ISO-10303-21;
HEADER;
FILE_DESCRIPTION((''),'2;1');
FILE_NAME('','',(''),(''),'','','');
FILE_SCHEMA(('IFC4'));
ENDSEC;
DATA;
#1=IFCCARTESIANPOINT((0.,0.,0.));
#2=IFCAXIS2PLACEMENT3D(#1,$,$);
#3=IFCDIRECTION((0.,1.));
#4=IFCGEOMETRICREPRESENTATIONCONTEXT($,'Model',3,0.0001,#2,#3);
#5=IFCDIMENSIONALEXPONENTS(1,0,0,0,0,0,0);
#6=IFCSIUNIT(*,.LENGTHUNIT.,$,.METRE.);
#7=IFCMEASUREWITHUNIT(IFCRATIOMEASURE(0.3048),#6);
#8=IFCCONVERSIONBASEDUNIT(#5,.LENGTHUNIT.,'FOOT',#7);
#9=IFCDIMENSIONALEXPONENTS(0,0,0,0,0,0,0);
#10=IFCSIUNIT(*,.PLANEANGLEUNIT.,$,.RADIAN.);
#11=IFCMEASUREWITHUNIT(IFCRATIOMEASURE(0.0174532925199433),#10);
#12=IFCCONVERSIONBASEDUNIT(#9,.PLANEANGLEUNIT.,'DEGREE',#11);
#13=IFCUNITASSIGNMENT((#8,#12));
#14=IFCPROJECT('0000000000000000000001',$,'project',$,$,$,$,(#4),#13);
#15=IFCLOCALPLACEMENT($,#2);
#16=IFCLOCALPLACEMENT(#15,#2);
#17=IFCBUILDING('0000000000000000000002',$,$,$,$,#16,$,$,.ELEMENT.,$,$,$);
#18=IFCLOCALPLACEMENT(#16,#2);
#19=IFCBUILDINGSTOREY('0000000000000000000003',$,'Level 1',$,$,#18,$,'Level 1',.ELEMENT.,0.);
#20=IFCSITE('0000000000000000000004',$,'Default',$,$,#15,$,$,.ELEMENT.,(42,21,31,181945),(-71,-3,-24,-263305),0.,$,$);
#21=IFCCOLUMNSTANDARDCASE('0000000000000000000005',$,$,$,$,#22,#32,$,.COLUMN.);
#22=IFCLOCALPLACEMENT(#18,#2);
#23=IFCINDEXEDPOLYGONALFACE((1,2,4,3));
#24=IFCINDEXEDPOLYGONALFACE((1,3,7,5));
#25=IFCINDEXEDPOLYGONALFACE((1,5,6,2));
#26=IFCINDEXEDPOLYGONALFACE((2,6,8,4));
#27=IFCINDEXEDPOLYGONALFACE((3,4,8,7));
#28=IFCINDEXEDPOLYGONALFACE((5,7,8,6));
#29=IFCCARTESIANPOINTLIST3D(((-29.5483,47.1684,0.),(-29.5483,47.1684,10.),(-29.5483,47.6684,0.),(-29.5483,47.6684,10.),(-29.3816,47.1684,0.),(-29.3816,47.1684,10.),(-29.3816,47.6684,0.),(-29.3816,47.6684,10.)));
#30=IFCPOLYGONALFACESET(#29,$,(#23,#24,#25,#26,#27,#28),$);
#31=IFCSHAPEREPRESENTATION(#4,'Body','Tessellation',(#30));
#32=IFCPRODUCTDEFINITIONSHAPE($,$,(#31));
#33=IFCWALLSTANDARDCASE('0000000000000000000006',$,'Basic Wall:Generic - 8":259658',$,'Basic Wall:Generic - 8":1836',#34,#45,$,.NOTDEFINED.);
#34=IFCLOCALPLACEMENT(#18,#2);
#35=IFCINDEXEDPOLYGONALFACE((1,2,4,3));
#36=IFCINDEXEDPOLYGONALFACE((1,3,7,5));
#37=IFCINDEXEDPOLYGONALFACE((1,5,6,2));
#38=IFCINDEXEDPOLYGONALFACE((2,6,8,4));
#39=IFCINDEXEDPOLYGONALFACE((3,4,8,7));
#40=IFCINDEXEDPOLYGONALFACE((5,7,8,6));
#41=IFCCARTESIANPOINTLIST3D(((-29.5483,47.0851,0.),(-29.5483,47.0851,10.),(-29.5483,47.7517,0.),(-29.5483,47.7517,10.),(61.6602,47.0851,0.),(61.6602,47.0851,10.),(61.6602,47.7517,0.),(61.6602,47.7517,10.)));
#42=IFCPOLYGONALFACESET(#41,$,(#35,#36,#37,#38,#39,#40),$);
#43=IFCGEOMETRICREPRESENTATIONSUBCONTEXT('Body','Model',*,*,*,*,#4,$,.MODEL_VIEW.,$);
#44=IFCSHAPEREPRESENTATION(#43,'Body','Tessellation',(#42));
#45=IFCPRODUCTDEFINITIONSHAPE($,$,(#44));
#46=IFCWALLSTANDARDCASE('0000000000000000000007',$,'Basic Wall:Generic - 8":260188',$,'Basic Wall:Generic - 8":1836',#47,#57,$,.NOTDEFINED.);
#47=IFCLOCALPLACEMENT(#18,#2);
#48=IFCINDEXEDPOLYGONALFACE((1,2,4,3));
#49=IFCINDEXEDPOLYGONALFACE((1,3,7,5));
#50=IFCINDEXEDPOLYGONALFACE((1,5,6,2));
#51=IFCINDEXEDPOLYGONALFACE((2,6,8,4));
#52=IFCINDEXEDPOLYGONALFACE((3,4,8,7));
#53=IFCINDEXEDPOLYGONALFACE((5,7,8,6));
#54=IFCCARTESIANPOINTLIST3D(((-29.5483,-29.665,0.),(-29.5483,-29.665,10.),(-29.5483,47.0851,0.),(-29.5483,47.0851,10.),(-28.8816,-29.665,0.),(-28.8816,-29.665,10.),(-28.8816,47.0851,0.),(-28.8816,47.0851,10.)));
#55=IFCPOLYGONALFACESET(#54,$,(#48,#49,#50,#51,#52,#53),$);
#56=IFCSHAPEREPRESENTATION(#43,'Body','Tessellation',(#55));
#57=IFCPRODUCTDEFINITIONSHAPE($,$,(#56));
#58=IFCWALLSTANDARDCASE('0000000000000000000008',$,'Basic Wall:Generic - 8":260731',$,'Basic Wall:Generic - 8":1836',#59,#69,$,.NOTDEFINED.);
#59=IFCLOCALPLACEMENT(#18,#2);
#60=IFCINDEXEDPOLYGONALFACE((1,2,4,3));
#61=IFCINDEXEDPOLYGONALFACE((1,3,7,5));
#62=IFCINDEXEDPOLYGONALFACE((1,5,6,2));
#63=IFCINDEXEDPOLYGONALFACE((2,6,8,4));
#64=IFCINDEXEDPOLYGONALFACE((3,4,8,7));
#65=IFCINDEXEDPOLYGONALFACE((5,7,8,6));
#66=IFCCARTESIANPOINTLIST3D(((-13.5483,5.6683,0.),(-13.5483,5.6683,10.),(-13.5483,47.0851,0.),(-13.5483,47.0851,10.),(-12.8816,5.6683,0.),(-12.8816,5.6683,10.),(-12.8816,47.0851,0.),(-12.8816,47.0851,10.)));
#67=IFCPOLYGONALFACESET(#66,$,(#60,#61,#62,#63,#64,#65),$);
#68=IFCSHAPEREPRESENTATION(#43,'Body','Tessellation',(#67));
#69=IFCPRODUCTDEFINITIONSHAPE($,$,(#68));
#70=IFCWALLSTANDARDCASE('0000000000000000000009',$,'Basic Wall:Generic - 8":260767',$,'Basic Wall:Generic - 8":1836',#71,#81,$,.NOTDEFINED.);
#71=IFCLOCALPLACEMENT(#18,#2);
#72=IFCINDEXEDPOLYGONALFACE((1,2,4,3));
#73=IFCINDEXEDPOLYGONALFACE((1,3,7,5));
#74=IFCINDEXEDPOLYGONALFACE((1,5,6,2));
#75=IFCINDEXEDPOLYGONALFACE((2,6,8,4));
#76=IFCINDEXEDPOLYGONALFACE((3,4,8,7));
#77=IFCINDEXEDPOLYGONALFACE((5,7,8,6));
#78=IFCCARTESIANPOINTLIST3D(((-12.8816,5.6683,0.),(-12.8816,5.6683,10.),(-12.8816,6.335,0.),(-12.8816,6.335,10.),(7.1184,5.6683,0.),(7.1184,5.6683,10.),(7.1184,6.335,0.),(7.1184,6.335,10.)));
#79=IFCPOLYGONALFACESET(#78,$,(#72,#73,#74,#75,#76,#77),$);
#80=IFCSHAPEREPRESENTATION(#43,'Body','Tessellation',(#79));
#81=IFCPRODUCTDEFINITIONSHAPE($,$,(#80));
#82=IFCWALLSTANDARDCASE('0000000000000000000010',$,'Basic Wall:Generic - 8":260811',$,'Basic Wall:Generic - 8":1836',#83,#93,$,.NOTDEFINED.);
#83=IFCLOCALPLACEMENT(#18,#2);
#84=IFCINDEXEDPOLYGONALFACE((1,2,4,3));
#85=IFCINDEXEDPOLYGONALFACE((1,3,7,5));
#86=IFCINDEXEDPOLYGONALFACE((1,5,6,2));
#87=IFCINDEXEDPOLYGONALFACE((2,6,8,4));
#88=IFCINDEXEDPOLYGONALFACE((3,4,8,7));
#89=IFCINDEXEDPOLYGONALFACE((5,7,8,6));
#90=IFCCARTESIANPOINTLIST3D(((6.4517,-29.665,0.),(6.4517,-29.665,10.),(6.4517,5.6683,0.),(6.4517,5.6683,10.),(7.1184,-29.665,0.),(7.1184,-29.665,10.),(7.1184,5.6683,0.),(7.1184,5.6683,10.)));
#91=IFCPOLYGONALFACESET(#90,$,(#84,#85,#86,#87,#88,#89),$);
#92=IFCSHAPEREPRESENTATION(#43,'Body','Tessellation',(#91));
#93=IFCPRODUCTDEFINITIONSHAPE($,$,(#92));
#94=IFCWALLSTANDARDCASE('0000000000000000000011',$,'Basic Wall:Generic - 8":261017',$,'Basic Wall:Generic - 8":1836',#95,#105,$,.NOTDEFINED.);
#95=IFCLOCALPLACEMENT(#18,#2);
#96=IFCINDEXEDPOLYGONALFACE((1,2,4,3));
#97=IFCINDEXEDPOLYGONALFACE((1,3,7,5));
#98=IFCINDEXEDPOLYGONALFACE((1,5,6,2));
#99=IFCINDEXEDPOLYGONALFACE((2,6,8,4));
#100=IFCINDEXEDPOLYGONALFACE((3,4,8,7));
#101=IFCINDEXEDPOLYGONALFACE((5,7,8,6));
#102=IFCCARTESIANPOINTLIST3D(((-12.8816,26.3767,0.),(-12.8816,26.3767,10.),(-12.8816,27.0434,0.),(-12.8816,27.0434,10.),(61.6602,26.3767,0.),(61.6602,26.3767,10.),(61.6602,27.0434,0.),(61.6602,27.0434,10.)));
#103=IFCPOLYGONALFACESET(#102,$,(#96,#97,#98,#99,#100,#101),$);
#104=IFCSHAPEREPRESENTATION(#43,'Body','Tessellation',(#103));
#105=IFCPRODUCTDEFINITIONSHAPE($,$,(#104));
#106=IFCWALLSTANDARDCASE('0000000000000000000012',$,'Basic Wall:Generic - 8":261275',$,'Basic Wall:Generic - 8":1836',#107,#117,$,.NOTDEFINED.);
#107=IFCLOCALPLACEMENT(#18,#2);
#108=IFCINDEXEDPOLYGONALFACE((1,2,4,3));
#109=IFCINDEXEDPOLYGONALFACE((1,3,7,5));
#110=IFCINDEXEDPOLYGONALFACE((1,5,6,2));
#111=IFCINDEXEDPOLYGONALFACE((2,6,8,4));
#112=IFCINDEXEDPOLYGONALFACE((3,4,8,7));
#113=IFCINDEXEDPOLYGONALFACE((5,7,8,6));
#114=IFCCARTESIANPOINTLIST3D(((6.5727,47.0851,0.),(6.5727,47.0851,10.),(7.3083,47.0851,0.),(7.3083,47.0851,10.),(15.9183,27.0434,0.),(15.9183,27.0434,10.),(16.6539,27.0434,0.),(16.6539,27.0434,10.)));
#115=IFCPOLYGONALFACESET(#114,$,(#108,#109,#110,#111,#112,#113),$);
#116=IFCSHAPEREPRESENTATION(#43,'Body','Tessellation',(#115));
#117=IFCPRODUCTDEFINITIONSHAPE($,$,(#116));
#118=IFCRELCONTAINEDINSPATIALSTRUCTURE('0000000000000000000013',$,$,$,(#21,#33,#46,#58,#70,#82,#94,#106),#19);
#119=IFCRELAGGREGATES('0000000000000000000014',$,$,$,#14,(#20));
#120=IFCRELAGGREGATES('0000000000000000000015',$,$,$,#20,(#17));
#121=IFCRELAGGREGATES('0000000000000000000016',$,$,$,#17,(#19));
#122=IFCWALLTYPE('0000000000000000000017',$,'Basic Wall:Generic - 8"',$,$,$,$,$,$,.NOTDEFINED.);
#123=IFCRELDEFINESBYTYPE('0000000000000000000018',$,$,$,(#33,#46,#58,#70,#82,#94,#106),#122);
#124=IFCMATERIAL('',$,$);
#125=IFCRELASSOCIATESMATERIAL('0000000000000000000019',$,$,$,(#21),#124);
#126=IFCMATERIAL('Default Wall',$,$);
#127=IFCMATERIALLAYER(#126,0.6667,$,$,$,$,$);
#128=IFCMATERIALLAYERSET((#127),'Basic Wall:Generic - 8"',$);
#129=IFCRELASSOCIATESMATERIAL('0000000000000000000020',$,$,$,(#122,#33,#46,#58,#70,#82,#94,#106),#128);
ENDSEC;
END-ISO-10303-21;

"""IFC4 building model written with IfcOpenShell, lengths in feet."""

from ifc_helpers import new_model, entity, si_unit, converted_unit, direction, frame, frame_2d, origin, place, context, subcontext, project, spatial, polyline, rectangle, outline, extrude, material, layer, layer_set, layer_usage, type_object, element, save


model = new_model("IFC4")

# Units and contexts
model_context = context("Model", 3, precision=0.0001, world=origin(), true_north=direction((0.0, 1.0)))
body_context = subcontext(model_context, "Body", "Model", "MODEL_VIEW")
ifc_project = project(units=[converted_unit("LENGTHUNIT", "FOOT", entity("IfcRatioMeasure", 0.3048), si_unit("LENGTHUNIT", "METRE"), dimensions=[1, 0, 0, 0, 0, 0, 0]), converted_unit("PLANEANGLEUNIT", "DEGREE", entity("IfcRatioMeasure", 0.0174532925199433), si_unit("PLANEANGLEUNIT", "RADIAN"), dimensions=[0, 0, 0, 0, 0, 0, 0])], contexts=[model_context])

# Site, building, storey
site_placement = place(None, origin())
site = spatial("IfcSite", under=ifc_project, at=site_placement, Name="Default", CompositionType="ELEMENT", RefLatitude=(42, 21, 31, 181945), RefLongitude=(-71, -3, -24, -263305), RefElevation=0.0)
building_placement = place(site_placement, origin())
building = spatial("IfcBuilding", under=site, at=building_placement, CompositionType="ELEMENT")
storey_placement = place(building_placement, origin())
storey = spatial("IfcBuildingStorey", under=building, at=storey_placement, Name="Level 1", LongName="Level 1", CompositionType="ELEMENT", Elevation=0.0)

# Column
ifc_material_1 = material(Name="")
wall_1_placement = place(storey_placement, frame((-29.5483, 47.4184, 0.0)))
for number, where, z_axis, x_axis in (
    (1, (0.0833, 0.0, 0.0), (0.0, 0.0, 1.0), (1.0, 0.0, 0.0)),
):
    element("IfcColumnStandardCase", number, at=place(wall_1_placement, frame(where, z_axis=z_axis, x_axis=x_axis)), inside=storey, material=ifc_material_1, PredefinedType="COLUMN", context=model_context, shape_type="SweptSolid", body=[
        extrude(rectangle(XDim=0.1667, YDim=0.5), origin(), (0.0, 0.0, 1.0), 10.0),
    ])

# Walls
ifc_material_2 = material(Name="Default Wall")
ifc_layer = layer(ifc_material_2, 0.6667)
ifc_layer_set = layer_set([ifc_layer], Name="Basic Wall:Generic - 8\"")
ifc_layer_usage_1 = layer_usage(ifc_layer_set, "AXIS2", "NEGATIVE", 0.3333)
wall_type = type_object("IfcWallType", Name="Basic Wall:Generic - 8\"", PredefinedType="NOTDEFINED", material=ifc_layer_set)
element("IfcWallStandardCase", 2, at=wall_1_placement, inside=storey, type_object=wall_type, material=ifc_layer_usage_1, Name="Basic Wall:Generic - 8\":259658", ObjectType="Basic Wall:Generic - 8\":1836", PredefinedType="NOTDEFINED", context=body_context, shape_type="SweptSolid", body=[
    extrude(rectangle(XDim=91.2085, YDim=0.6667, at=frame_2d((45.6043, 0.0), x_axis=(-1.0, 0.0))), origin(), (0.0, 0.0, 1.0), 10.0),
])
ifc_layer_usage_2 = layer_usage(ifc_layer_set, "AXIS2", "NEGATIVE", 0.3333)
wall_2_placement = place(storey_placement, frame((-29.215, 47.0851, 0.0), z_axis=(0.0, 0.0, 1.0), x_axis=(0.0, -1.0, 0.0)))
element("IfcWallStandardCase", 3, at=wall_2_placement, inside=storey, type_object=wall_type, material=ifc_layer_usage_2, Name="Basic Wall:Generic - 8\":260188", ObjectType="Basic Wall:Generic - 8\":1836", PredefinedType="NOTDEFINED", context=body_context, shape_type="SweptSolid", body=[
    extrude(rectangle(XDim=76.7501, YDim=0.6667, at=frame_2d((38.375, 0.0), x_axis=(-1.0, 0.0))), origin(), (0.0, 0.0, 1.0), 10.0),
])
ifc_layer_usage_3 = layer_usage(ifc_layer_set, "AXIS2", "NEGATIVE", 0.3333)
wall_3_placement = place(storey_placement, frame((-13.215, 47.0851, 0.0), z_axis=(0.0, 0.0, 1.0), x_axis=(0.0, -1.0, 0.0)))
element("IfcWallStandardCase", 4, at=wall_3_placement, inside=storey, type_object=wall_type, material=ifc_layer_usage_3, Name="Basic Wall:Generic - 8\":260731", ObjectType="Basic Wall:Generic - 8\":1836", PredefinedType="NOTDEFINED", context=body_context, shape_type="SweptSolid", body=[
    extrude(rectangle(XDim=41.4167, YDim=0.6667, at=frame_2d((20.7084, 0.0), x_axis=(-1.0, 0.0))), origin(), (0.0, 0.0, 1.0), 10.0),
])
ifc_layer_usage_4 = layer_usage(ifc_layer_set, "AXIS2", "NEGATIVE", 0.3333)
wall_4_placement = place(storey_placement, frame((-12.8816, 6.0017, 0.0)))
element("IfcWallStandardCase", 5, at=wall_4_placement, inside=storey, type_object=wall_type, material=ifc_layer_usage_4, Name="Basic Wall:Generic - 8\":260767", ObjectType="Basic Wall:Generic - 8\":1836", PredefinedType="NOTDEFINED", context=body_context, shape_type="SweptSolid", body=[
    extrude(rectangle(XDim=20.0, YDim=0.6667, at=frame_2d((10.0, 0.0), x_axis=(-1.0, 0.0))), origin(), (0.0, 0.0, 1.0), 10.0),
])
ifc_layer_usage_5 = layer_usage(ifc_layer_set, "AXIS2", "NEGATIVE", 0.3333)
wall_5_placement = place(storey_placement, frame((6.785, 5.6683, 0.0), z_axis=(0.0, 0.0, 1.0), x_axis=(0.0, -1.0, 0.0)))
element("IfcWallStandardCase", 6, at=wall_5_placement, inside=storey, type_object=wall_type, material=ifc_layer_usage_5, Name="Basic Wall:Generic - 8\":260811", ObjectType="Basic Wall:Generic - 8\":1836", PredefinedType="NOTDEFINED", context=body_context, shape_type="SweptSolid", body=[
    extrude(rectangle(XDim=35.3333, YDim=0.6667, at=frame_2d((17.6667, 0.0), x_axis=(-1.0, 0.0))), origin(), (0.0, 0.0, 1.0), 10.0),
])
ifc_layer_usage_6 = layer_usage(ifc_layer_set, "AXIS2", "NEGATIVE", 0.3333)
wall_6_placement = place(storey_placement, frame((-12.8816, 26.71, 0.0)))
element("IfcWallStandardCase", 7, at=wall_6_placement, inside=storey, type_object=wall_type, material=ifc_layer_usage_6, Name="Basic Wall:Generic - 8\":261017", ObjectType="Basic Wall:Generic - 8\":1836", PredefinedType="NOTDEFINED", context=body_context, shape_type="SweptSolid", body=[
    extrude(rectangle(XDim=74.5419, YDim=0.6667, at=frame_2d((37.2709, 0.0), x_axis=(-1.0, 0.0))), origin(), (0.0, 0.0, 1.0), 10.0),
])
ifc_layer_usage_7 = layer_usage(ifc_layer_set, "AXIS2", "NEGATIVE", 0.3333)
wall_7_placement = place(storey_placement, frame((6.8748, 47.226, 0.0), z_axis=(0.0, 0.0, 1.0), x_axis=(0.422618, -0.906308, 0.0)))
element("IfcWallStandardCase", 8, at=wall_7_placement, inside=storey, type_object=wall_type, material=ifc_layer_usage_7, Name="Basic Wall:Generic - 8\":261275", ObjectType="Basic Wall:Generic - 8\":1836", PredefinedType="NOTDEFINED", context=body_context, shape_type="SweptSolid", body=[
    extrude(outline(polyline([(22.1136, -0.3333), (22.4244, 0.3333), (0.3109, 0.3333), (0.0, -0.3333), (22.1136, -0.3333)])), origin(), (0.0, 0.0, 1.0), 10.0),
])

save(model, "model.ifc")
